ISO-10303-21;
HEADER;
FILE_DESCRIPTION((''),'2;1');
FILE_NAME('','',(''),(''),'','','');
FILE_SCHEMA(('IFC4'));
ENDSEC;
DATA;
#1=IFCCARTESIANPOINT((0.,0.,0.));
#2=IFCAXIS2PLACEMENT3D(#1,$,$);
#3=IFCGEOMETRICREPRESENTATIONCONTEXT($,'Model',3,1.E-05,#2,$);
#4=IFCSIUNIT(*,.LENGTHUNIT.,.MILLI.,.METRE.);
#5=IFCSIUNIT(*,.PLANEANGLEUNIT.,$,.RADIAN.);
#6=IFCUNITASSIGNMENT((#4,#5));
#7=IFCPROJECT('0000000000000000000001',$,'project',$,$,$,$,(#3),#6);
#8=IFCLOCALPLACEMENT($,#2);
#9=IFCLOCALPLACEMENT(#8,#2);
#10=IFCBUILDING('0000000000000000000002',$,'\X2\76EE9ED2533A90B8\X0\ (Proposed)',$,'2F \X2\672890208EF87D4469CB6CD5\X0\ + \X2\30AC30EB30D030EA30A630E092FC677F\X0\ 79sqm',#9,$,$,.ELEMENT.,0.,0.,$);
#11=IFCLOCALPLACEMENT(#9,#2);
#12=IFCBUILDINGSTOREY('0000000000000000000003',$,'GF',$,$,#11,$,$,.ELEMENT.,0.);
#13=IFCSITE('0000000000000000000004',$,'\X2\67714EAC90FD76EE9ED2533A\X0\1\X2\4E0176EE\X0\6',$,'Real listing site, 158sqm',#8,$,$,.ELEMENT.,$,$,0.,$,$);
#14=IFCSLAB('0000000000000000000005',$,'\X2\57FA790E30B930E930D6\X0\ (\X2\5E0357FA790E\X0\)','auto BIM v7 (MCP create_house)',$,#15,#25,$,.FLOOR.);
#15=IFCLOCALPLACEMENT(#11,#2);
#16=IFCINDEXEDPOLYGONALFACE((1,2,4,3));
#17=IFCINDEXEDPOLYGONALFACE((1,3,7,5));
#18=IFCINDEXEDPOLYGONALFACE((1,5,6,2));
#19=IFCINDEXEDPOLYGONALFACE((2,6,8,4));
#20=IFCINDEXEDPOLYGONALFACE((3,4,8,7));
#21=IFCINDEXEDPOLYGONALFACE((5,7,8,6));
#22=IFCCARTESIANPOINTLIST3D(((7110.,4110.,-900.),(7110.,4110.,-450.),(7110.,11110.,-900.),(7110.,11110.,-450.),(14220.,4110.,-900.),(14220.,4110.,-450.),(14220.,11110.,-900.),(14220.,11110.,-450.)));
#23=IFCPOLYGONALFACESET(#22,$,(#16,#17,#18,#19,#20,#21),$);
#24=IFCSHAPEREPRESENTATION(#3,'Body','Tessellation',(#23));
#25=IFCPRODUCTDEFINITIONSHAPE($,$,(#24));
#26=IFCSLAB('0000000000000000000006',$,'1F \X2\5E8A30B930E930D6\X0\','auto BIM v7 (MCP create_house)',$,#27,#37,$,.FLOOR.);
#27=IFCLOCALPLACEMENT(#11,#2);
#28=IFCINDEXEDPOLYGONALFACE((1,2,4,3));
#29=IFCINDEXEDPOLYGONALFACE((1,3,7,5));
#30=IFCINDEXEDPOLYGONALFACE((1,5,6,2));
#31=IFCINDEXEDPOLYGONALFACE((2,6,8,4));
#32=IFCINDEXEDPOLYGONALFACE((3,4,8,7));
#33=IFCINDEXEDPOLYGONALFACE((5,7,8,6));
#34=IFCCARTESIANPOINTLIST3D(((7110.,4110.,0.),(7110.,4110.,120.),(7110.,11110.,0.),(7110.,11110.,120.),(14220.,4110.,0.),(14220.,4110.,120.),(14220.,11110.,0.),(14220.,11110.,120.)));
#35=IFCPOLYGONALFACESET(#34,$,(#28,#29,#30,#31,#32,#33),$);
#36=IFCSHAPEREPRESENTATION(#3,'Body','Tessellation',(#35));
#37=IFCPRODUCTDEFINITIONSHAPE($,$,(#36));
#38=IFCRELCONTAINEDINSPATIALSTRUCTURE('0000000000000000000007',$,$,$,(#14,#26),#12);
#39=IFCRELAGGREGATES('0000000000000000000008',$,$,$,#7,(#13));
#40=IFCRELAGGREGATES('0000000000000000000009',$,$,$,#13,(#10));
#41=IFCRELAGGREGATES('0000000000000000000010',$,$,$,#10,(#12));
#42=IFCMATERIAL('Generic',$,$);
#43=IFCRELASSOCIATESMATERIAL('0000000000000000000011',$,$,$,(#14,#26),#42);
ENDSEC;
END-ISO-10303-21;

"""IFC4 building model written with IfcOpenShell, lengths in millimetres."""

from ifc_helpers import new_model, si_unit, frame, frame_2d, origin, place, context, project, spatial, rectangle, extrude, material, element, save


model = new_model("IFC4")

# Units and contexts
model_context = context("Model", 3, precision=1e-05, world=origin())
ifc_project = project(units=[si_unit("LENGTHUNIT", "METRE", prefix="MILLI"), si_unit("PLANEANGLEUNIT", "RADIAN")], contexts=[model_context])

# Site, building, storey
site_placement = place(None, origin())
site = spatial("IfcSite", under=ifc_project, at=site_placement, Name="東京都目黒区1丁目6", ObjectType="Real listing site, 158sqm", CompositionType="ELEMENT", RefElevation=0.0)
building_placement = place(site_placement, origin())
building = spatial("IfcBuilding", under=site, at=building_placement, Name="目黒区邸 (Proposed)", ObjectType="2F 木造軸組構法 + ガルバリウム鋼板 79sqm", CompositionType="ELEMENT", ElevationOfRefHeight=0.0, ElevationOfTerrain=0.0)
storey_placement = place(building_placement, origin())
storey = spatial("IfcBuildingStorey", under=building, at=storey_placement, Name="GF", CompositionType="ELEMENT", Elevation=0.0)

# Slabs
ifc_material = material(Name="Generic")
slab_1_placement = place(storey_placement, frame((3555.0, 2055.0, -450.0)))
element("IfcSlab", 1, at=slab_1_placement, inside=storey, material=ifc_material, Name="基礎スラブ (布基礎)", Description="auto BIM v7 (MCP create_house)", PredefinedType="FLOOR", context=model_context, shape_type="SweptSolid", body=[
    extrude(rectangle(XDim=7110.0, YDim=7000.0, at=frame_2d((3555.0, 3500.0))), frame((3555.0, 2055.0, -450.0)), (0.0, 0.0, 1.0), 450.0),
])
slab_2_placement = place(storey_placement, frame((3555.0, 2055.0, 0.0)))
element("IfcSlab", 2, at=slab_2_placement, inside=storey, material=ifc_material, Name="1F 床スラブ", Description="auto BIM v7 (MCP create_house)", PredefinedType="FLOOR", context=model_context, shape_type="SweptSolid", body=[
    extrude(rectangle(XDim=7110.0, YDim=7000.0, at=frame_2d((3555.0, 3500.0))), frame((3555.0, 2055.0, 0.0)), (0.0, 0.0, 1.0), 120.0),
])

save(model, "model.ifc")
